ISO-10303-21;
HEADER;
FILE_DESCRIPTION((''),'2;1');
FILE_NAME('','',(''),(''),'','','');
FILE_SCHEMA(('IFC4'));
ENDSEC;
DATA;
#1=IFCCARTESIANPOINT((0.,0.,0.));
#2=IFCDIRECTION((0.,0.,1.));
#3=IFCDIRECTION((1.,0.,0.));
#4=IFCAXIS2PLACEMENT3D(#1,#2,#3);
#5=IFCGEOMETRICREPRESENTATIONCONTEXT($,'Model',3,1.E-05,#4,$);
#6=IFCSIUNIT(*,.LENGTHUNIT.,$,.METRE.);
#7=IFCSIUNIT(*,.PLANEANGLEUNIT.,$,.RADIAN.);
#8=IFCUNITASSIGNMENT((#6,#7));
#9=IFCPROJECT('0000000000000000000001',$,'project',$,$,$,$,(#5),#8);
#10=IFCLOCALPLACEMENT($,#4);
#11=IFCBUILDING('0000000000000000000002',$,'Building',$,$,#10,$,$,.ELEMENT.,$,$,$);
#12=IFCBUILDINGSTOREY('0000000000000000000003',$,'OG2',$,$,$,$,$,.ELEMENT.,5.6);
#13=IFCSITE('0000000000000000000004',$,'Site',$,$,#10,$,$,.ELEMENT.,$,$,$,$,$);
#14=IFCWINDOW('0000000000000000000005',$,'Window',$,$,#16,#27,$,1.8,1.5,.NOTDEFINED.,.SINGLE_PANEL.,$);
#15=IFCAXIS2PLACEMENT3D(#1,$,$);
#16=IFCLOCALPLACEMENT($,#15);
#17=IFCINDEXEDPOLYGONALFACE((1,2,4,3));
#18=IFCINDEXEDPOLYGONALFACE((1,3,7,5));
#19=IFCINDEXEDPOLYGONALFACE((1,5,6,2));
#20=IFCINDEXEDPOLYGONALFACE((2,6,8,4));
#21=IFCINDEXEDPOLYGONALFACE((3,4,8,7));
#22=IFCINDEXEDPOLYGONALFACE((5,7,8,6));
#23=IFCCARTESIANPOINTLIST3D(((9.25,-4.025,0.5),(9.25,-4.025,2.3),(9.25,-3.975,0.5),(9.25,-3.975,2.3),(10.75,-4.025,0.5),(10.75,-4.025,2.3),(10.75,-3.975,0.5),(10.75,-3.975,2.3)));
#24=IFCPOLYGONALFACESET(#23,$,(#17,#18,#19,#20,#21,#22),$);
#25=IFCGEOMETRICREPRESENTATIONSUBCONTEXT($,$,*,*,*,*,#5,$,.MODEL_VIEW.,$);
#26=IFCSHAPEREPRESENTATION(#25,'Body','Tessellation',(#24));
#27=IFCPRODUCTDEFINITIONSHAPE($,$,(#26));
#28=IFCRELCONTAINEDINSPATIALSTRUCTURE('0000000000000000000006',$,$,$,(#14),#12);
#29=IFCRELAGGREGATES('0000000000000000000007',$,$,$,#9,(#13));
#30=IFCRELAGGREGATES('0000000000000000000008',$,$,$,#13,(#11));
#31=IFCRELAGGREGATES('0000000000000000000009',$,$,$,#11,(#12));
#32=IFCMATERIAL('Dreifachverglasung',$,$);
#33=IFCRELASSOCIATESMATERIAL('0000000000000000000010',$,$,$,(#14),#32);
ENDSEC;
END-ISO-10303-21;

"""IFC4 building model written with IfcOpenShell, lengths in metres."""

from ifc_helpers import new_model, si_unit, frame, origin, origin_with_axes, origin_2d, place, context, subcontext, project, spatial, rectangle, extrude, material, element, save


model = new_model("IFC4")

# Units and contexts
model_context = context("Model", 3, precision=1e-05, world=origin_with_axes())
sub_context = subcontext(model_context, None, None, "MODEL_VIEW")
ifc_project = project(units=[si_unit("LENGTHUNIT", "METRE"), si_unit("PLANEANGLEUNIT", "RADIAN")], contexts=[model_context])

# Site, building, storey
placement_1 = place(None, origin_with_axes())
site = spatial("IfcSite", under=ifc_project, at=placement_1, Name="Site", CompositionType="ELEMENT")
building = spatial("IfcBuilding", under=site, at=placement_1, Name="Building", CompositionType="ELEMENT")
storey = spatial("IfcBuildingStorey", under=building, Name="OG2", CompositionType="ELEMENT", Elevation=5.6)

# Window
ifc_material = material(Name="Dreifachverglasung")
placement_2 = place(None, origin_with_axes())
window_placement = place(placement_2, frame((10.0, -4.0, 0.5)))
element("IfcWindow", 1, at=window_placement, inside=storey, material=ifc_material, Name="Window", OverallHeight=1.8, OverallWidth=1.5, PartitioningType="SINGLE_PANEL", PredefinedType="NOTDEFINED", context=sub_context, shape_type="SweptSolid", body=[
    extrude(rectangle(XDim=1.5, YDim=0.05, at=origin_2d()), origin(), (0.0, 0.0, 1.0), 1.8),
])

save(model, "model.ifc")
